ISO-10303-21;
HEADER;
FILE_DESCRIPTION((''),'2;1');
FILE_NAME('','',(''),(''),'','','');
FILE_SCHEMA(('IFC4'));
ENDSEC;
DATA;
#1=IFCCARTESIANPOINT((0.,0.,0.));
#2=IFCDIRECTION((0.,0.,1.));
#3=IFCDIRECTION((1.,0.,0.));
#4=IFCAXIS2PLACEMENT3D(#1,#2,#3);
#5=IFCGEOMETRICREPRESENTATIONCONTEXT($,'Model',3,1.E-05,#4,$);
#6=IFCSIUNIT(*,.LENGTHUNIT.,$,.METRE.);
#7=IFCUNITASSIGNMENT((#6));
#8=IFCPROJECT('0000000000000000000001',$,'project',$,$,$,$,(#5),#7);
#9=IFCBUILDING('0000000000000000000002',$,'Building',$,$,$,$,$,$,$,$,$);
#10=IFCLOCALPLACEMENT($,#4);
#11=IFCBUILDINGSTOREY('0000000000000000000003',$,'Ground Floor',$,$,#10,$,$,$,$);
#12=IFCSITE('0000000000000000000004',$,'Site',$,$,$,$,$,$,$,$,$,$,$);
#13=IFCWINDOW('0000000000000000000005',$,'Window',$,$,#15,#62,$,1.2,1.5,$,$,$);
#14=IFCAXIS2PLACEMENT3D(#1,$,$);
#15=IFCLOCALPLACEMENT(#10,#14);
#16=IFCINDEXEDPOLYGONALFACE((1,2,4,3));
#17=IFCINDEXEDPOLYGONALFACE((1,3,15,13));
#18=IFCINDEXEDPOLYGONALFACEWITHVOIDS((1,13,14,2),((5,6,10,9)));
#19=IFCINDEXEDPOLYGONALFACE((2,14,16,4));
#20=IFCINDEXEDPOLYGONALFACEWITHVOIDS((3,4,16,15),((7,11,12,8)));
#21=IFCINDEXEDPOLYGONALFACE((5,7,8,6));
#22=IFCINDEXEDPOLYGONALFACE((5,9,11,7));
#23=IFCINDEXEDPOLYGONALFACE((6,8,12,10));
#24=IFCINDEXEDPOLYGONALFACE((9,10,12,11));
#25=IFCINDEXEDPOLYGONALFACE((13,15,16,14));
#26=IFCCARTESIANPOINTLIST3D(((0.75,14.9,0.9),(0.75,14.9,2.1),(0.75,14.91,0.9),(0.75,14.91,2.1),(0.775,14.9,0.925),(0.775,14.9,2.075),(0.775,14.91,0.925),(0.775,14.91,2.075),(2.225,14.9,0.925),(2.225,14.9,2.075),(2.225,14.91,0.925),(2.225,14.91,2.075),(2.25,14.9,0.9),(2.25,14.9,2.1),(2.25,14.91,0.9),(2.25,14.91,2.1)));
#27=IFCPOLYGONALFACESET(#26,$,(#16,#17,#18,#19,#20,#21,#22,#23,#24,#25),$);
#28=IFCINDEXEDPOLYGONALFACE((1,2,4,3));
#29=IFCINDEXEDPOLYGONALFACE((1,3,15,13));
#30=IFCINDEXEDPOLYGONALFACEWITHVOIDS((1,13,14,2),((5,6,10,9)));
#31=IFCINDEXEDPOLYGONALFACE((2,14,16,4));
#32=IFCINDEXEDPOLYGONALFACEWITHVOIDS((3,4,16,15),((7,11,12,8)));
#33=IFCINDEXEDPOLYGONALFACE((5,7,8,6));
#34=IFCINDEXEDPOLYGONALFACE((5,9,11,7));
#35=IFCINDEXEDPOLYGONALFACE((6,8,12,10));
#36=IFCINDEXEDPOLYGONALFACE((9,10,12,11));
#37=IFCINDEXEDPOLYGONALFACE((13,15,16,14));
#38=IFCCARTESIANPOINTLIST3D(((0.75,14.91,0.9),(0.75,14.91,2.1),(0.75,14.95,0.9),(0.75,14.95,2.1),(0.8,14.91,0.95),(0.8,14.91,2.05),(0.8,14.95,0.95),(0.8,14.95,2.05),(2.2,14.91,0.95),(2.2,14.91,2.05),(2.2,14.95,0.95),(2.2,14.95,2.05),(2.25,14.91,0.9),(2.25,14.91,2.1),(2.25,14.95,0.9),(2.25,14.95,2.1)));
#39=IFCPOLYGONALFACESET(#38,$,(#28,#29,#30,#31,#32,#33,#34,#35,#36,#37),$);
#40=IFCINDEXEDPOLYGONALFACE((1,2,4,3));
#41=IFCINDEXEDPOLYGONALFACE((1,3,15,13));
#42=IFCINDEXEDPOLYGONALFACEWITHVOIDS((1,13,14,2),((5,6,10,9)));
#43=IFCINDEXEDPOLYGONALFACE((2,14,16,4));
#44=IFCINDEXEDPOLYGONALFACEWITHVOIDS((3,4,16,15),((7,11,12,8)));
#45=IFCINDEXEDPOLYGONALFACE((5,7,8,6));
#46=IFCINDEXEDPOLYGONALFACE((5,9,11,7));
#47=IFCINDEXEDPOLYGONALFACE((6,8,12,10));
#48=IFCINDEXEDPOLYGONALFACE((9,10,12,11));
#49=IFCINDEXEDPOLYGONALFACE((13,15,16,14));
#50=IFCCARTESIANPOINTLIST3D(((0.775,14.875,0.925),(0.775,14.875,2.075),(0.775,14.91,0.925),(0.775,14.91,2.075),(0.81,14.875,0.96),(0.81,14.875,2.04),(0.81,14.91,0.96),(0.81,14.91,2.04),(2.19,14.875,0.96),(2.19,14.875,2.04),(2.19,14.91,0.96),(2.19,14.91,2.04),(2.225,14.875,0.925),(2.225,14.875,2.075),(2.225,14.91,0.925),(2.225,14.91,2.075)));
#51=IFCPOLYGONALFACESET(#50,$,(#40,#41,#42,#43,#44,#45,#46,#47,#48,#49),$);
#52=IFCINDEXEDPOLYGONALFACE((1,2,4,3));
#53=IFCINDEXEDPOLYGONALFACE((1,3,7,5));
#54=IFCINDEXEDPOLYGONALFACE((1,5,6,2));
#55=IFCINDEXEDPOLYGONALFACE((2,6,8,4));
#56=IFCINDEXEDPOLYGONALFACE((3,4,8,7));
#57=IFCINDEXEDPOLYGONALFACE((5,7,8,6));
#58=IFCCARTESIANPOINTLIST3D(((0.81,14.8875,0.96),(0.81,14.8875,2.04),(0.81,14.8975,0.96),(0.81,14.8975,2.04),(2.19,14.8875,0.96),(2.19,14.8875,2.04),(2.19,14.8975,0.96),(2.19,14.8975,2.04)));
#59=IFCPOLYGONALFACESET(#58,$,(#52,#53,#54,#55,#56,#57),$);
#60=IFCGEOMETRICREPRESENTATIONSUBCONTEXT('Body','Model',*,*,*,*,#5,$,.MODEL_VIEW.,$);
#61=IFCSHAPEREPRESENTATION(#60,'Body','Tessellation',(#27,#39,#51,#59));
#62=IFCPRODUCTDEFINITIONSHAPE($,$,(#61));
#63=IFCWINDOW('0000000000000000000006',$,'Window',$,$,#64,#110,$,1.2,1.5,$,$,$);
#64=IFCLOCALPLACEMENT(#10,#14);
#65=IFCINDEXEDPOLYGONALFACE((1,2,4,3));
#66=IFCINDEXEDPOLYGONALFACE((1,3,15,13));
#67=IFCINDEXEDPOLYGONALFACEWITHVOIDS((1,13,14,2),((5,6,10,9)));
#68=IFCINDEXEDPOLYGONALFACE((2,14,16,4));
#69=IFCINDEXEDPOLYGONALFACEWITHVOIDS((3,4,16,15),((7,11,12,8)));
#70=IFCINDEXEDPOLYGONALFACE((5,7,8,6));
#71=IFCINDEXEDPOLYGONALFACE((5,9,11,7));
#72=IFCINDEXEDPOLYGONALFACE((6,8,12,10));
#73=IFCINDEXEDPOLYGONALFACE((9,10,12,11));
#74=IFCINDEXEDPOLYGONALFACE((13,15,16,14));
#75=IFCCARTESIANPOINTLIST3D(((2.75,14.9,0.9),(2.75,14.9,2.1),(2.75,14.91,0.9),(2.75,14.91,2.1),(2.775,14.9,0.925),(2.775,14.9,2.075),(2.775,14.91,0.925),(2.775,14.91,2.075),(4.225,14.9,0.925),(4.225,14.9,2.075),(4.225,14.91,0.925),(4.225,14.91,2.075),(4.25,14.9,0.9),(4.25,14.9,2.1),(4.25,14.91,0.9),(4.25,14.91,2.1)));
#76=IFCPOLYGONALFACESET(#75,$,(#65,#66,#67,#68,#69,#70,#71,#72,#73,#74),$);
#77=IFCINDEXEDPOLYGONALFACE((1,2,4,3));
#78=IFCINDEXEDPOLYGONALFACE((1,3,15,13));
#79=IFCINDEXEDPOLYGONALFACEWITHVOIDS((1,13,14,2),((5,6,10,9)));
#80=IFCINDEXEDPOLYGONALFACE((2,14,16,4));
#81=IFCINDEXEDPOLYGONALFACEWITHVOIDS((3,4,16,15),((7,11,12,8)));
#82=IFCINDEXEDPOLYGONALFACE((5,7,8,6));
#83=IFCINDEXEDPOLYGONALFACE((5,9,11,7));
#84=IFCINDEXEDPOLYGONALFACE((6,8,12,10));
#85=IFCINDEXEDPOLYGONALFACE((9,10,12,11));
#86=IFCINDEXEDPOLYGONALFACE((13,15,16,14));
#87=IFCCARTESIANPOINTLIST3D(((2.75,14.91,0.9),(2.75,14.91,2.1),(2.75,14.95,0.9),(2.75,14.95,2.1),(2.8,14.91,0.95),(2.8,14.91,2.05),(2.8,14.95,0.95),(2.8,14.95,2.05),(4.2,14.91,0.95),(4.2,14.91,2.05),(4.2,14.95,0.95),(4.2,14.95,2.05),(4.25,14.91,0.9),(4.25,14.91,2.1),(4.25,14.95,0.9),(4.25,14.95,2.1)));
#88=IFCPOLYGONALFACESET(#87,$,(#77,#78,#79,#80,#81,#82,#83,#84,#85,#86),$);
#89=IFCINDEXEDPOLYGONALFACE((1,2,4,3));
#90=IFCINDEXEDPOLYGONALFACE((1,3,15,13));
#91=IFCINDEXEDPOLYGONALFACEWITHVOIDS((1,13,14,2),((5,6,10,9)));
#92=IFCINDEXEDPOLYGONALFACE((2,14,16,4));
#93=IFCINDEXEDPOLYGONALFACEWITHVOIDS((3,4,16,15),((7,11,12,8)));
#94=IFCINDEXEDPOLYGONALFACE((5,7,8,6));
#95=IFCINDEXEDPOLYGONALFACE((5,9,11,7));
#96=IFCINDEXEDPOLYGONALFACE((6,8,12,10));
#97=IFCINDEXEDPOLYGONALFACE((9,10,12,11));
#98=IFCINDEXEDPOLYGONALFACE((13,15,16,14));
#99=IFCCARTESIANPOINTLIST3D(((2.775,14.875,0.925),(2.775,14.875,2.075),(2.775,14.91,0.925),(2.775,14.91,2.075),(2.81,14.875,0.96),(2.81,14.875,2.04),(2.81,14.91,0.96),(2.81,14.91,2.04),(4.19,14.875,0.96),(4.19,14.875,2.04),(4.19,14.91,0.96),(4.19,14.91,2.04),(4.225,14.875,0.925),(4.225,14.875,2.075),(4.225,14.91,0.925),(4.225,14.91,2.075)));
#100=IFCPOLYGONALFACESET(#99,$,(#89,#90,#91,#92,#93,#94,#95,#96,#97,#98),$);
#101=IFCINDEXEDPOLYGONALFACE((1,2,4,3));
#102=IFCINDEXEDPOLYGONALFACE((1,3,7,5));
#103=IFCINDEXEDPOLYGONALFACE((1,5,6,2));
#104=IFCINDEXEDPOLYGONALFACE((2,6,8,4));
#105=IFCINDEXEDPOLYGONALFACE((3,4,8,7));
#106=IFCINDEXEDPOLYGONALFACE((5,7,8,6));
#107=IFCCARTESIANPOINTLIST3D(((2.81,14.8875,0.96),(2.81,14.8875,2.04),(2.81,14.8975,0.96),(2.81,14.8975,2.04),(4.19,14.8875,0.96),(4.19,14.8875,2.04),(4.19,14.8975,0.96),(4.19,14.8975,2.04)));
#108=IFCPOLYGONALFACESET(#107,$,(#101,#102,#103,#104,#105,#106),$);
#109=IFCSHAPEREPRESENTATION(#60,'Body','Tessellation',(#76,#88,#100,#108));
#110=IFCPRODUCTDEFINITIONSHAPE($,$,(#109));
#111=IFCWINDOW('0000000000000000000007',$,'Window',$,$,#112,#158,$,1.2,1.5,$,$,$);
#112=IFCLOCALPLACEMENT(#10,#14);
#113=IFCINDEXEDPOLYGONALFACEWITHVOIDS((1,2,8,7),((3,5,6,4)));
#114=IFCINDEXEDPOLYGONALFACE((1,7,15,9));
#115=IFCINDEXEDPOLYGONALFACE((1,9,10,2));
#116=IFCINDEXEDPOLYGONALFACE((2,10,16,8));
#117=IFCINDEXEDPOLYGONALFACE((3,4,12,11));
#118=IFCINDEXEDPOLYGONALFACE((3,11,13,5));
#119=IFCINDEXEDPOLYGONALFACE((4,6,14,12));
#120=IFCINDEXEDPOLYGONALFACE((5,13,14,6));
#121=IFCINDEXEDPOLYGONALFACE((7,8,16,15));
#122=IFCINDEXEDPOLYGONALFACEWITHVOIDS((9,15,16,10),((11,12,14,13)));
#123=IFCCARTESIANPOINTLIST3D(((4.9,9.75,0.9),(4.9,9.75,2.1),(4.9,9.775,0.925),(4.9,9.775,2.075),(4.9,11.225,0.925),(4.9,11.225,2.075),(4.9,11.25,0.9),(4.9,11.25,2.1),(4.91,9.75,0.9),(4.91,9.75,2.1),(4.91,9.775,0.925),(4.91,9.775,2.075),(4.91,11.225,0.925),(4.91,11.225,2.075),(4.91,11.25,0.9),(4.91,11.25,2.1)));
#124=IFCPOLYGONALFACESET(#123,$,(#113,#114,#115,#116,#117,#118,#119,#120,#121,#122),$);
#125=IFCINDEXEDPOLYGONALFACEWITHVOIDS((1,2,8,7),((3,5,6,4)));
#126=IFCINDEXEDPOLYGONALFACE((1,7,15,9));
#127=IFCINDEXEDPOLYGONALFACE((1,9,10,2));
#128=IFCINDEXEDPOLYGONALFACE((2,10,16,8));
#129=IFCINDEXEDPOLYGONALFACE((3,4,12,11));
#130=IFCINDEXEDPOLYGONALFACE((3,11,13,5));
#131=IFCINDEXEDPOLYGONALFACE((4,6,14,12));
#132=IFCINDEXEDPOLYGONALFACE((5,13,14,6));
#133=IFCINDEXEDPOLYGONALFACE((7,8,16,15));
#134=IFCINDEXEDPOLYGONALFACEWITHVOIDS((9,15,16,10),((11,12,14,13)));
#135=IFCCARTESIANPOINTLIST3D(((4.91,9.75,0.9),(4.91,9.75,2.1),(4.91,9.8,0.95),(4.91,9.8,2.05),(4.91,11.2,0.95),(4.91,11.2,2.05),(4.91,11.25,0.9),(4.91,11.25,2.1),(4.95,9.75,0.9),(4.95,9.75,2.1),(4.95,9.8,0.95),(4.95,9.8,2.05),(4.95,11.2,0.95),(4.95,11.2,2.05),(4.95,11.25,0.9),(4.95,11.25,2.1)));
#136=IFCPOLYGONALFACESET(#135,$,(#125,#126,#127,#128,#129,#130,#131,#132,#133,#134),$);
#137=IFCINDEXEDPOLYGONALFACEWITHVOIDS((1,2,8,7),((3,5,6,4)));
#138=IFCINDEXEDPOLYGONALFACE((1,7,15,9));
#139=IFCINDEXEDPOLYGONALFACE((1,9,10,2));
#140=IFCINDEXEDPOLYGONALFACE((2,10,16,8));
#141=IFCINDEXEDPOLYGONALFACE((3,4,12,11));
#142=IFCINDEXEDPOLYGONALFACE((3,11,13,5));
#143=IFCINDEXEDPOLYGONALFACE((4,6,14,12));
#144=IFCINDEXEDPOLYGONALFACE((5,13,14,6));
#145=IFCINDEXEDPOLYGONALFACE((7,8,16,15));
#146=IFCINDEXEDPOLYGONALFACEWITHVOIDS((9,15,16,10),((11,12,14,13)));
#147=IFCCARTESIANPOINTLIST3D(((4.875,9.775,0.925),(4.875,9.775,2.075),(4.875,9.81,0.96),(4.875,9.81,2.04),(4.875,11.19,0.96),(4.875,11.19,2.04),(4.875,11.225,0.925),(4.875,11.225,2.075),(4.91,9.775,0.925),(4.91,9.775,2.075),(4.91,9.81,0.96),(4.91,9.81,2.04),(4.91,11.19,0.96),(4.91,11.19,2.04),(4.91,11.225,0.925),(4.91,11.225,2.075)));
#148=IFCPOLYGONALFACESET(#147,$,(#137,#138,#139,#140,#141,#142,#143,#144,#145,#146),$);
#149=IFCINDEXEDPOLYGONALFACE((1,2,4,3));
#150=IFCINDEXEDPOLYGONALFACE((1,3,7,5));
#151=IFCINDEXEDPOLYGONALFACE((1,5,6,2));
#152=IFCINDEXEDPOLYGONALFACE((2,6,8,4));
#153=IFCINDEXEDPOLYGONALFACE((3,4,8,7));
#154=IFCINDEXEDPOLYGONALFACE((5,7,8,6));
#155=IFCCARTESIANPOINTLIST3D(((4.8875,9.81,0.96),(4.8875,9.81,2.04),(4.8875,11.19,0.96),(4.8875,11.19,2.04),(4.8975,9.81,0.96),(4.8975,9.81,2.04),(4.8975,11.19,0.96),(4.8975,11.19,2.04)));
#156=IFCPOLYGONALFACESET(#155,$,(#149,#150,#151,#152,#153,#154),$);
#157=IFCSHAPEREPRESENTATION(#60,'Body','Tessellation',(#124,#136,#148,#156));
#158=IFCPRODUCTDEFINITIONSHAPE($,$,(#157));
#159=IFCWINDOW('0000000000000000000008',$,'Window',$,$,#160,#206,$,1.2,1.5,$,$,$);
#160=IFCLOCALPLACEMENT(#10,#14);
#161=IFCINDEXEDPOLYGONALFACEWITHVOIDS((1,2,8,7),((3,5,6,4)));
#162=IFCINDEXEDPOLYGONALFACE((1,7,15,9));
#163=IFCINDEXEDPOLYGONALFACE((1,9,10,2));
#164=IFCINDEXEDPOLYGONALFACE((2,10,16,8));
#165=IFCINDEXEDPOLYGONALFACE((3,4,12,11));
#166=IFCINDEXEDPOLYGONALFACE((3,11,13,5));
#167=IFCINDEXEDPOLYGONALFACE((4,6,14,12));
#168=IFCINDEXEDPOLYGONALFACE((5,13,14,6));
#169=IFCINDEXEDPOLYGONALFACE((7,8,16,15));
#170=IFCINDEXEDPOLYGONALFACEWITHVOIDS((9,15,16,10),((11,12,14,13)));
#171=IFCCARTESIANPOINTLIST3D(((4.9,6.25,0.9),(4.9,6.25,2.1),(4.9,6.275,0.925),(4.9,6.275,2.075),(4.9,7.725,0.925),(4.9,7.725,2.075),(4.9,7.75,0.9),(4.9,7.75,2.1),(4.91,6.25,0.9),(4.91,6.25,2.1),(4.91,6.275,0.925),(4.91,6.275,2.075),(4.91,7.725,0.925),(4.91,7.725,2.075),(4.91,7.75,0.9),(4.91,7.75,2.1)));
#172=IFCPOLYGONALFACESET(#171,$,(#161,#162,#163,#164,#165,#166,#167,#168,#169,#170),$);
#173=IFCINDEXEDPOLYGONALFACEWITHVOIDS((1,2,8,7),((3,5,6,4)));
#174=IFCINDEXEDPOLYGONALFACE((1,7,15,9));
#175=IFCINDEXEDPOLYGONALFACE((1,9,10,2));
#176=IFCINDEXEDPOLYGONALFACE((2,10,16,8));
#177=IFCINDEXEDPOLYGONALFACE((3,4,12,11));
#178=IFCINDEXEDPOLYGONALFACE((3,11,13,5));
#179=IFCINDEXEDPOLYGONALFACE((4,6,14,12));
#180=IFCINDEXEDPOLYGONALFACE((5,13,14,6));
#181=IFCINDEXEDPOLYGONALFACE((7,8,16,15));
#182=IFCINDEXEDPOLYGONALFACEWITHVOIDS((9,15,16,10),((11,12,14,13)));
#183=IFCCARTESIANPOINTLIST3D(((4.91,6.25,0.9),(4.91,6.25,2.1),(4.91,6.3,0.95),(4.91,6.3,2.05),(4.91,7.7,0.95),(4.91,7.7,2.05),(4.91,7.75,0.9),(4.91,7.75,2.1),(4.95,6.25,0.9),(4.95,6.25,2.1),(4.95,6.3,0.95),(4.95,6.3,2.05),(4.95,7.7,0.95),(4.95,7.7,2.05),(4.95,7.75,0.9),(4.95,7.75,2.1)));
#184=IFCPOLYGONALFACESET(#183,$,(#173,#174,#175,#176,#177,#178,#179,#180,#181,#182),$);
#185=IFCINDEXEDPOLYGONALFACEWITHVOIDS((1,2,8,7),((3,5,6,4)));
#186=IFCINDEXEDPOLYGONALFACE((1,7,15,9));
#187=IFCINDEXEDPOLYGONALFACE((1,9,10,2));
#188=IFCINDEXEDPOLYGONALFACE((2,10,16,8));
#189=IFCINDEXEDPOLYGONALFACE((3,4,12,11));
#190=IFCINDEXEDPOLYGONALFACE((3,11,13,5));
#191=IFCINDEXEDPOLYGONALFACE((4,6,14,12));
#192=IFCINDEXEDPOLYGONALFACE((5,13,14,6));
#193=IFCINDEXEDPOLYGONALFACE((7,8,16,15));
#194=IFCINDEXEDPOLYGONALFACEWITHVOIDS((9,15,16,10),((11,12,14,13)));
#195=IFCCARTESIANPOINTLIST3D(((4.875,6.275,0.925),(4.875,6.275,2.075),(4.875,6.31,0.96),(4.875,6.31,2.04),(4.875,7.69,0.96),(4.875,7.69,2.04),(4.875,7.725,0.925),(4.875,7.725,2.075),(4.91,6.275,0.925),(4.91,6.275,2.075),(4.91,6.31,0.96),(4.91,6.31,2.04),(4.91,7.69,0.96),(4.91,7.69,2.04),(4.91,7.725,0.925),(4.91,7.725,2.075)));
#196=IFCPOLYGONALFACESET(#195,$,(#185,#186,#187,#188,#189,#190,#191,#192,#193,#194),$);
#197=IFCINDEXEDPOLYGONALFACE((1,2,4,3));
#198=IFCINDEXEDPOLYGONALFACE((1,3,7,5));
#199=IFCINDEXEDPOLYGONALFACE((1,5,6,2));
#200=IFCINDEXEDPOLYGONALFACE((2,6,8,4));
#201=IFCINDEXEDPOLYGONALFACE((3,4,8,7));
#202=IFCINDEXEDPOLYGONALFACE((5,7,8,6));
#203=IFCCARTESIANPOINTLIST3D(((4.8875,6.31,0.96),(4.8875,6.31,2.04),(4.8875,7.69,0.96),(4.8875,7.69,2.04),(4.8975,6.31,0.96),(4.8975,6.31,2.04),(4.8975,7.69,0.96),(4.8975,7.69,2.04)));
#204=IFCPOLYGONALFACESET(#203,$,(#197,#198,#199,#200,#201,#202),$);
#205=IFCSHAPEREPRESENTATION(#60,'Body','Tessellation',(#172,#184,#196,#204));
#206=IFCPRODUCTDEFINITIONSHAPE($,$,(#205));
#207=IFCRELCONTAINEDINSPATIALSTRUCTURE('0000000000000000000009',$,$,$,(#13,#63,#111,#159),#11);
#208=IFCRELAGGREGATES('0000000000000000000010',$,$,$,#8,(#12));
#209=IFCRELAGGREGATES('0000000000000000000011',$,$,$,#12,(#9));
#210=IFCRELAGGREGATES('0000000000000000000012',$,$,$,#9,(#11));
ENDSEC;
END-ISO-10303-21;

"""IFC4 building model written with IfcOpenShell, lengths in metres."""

from ifc_helpers import new_model, si_unit, frame, origin_with_axes, place, context, subcontext, project, spatial, line, indexed_curve, outline, extrude, element, save


model = new_model("IFC4")

# Units and contexts
model_context = context("Model", 3, precision=1e-05, world=origin_with_axes())
body_context = subcontext(model_context, "Body", "Model", "MODEL_VIEW")
ifc_project = project(units=[si_unit("LENGTHUNIT", "METRE")], contexts=[model_context])

# Site, building, storey
site = spatial("IfcSite", under=ifc_project, Name="Site")
building = spatial("IfcBuilding", under=site, Name="Building")
storey_placement = place(None, origin_with_axes())
storey = spatial("IfcBuildingStorey", under=building, at=storey_placement, Name="Ground Floor")

# Windows
for number, where, z_axis, x_axis, name in (
    (1, (2.25, 15.0, 0.9), (0.0, 0.0, 1.0), (-1.0, 0.0, 0.0), "Window"),
    (2, (4.25, 15.0, 0.9), (0.0, 0.0, 1.0), (-1.0, 0.0, 0.0), "Window"),
    (3, (5.0, 9.75, 0.9), (0.0, 0.0, 1.0), (0.0, 1.0, 0.0), "Window"),
    (4, (5.0, 6.25, 0.9), (0.0, 0.0, 1.0), (0.0, 1.0, 0.0), "Window"),
):
    element("IfcWindow", number, at=place(storey_placement, frame(where, z_axis=z_axis, x_axis=x_axis)), inside=storey, Name=name, OverallHeight=1.2, OverallWidth=1.5, context=body_context, shape_type="SweptSolid", body=[
        extrude(outline(indexed_curve([(0.0, 0.0), (1.5, 0.0), (1.5, 1.2), (0.0, 1.2)], segments=[line(1, 2, 3, 4, 1)]), holes=[indexed_curve([(0.025, 0.025), (1.475, 0.025), (1.475, 1.175), (0.025, 1.175)], segments=[line(1, 2, 3, 4, 1)])]), frame((0.0, 0.09, 0.0), z_axis=(0.0, -1.0, 0.0), x_axis=(1.0, 0.0, 0.0)), (0.0, 0.0, -1.0), 0.01),
        extrude(outline(indexed_curve([(0.0, 0.0), (1.5, 0.0), (1.5, 1.2), (0.0, 1.2)], segments=[line(1, 2, 3, 4, 1)]), holes=[indexed_curve([(0.05, 0.05), (1.45, 0.05), (1.45, 1.15), (0.05, 1.15)], segments=[line(1, 2, 3, 4, 1)])]), frame((0.0, 0.05, 0.0), z_axis=(0.0, -1.0, 0.0), x_axis=(1.0, 0.0, 0.0)), (0.0, 0.0, -1.0), 0.04),
        extrude(outline(indexed_curve([(0.0, 0.0), (1.45, 0.0), (1.45, 1.15), (0.0, 1.15)], segments=[line(1, 2, 3, 4, 1)]), holes=[indexed_curve([(0.035, 0.035), (1.415, 0.035), (1.415, 1.115), (0.035, 1.115)], segments=[line(1, 2, 3, 4, 1)])]), frame((0.025, 0.09, 0.025), z_axis=(0.0, -1.0, 0.0), x_axis=(1.0, 0.0, 0.0)), (0.0, 0.0, -1.0), 0.035),
        extrude(outline(indexed_curve([(0.035, 0.035), (1.415, 0.035), (1.415, 1.115), (0.035, 1.115)], segments=[line(1, 2, 3, 4, 1)])), frame((0.025, 0.1025, 0.025), z_axis=(0.0, -1.0, 0.0), x_axis=(1.0, 0.0, 0.0)), (0.0, 0.0, -1.0), 0.01),
    ])

save(model, "model.ifc")
